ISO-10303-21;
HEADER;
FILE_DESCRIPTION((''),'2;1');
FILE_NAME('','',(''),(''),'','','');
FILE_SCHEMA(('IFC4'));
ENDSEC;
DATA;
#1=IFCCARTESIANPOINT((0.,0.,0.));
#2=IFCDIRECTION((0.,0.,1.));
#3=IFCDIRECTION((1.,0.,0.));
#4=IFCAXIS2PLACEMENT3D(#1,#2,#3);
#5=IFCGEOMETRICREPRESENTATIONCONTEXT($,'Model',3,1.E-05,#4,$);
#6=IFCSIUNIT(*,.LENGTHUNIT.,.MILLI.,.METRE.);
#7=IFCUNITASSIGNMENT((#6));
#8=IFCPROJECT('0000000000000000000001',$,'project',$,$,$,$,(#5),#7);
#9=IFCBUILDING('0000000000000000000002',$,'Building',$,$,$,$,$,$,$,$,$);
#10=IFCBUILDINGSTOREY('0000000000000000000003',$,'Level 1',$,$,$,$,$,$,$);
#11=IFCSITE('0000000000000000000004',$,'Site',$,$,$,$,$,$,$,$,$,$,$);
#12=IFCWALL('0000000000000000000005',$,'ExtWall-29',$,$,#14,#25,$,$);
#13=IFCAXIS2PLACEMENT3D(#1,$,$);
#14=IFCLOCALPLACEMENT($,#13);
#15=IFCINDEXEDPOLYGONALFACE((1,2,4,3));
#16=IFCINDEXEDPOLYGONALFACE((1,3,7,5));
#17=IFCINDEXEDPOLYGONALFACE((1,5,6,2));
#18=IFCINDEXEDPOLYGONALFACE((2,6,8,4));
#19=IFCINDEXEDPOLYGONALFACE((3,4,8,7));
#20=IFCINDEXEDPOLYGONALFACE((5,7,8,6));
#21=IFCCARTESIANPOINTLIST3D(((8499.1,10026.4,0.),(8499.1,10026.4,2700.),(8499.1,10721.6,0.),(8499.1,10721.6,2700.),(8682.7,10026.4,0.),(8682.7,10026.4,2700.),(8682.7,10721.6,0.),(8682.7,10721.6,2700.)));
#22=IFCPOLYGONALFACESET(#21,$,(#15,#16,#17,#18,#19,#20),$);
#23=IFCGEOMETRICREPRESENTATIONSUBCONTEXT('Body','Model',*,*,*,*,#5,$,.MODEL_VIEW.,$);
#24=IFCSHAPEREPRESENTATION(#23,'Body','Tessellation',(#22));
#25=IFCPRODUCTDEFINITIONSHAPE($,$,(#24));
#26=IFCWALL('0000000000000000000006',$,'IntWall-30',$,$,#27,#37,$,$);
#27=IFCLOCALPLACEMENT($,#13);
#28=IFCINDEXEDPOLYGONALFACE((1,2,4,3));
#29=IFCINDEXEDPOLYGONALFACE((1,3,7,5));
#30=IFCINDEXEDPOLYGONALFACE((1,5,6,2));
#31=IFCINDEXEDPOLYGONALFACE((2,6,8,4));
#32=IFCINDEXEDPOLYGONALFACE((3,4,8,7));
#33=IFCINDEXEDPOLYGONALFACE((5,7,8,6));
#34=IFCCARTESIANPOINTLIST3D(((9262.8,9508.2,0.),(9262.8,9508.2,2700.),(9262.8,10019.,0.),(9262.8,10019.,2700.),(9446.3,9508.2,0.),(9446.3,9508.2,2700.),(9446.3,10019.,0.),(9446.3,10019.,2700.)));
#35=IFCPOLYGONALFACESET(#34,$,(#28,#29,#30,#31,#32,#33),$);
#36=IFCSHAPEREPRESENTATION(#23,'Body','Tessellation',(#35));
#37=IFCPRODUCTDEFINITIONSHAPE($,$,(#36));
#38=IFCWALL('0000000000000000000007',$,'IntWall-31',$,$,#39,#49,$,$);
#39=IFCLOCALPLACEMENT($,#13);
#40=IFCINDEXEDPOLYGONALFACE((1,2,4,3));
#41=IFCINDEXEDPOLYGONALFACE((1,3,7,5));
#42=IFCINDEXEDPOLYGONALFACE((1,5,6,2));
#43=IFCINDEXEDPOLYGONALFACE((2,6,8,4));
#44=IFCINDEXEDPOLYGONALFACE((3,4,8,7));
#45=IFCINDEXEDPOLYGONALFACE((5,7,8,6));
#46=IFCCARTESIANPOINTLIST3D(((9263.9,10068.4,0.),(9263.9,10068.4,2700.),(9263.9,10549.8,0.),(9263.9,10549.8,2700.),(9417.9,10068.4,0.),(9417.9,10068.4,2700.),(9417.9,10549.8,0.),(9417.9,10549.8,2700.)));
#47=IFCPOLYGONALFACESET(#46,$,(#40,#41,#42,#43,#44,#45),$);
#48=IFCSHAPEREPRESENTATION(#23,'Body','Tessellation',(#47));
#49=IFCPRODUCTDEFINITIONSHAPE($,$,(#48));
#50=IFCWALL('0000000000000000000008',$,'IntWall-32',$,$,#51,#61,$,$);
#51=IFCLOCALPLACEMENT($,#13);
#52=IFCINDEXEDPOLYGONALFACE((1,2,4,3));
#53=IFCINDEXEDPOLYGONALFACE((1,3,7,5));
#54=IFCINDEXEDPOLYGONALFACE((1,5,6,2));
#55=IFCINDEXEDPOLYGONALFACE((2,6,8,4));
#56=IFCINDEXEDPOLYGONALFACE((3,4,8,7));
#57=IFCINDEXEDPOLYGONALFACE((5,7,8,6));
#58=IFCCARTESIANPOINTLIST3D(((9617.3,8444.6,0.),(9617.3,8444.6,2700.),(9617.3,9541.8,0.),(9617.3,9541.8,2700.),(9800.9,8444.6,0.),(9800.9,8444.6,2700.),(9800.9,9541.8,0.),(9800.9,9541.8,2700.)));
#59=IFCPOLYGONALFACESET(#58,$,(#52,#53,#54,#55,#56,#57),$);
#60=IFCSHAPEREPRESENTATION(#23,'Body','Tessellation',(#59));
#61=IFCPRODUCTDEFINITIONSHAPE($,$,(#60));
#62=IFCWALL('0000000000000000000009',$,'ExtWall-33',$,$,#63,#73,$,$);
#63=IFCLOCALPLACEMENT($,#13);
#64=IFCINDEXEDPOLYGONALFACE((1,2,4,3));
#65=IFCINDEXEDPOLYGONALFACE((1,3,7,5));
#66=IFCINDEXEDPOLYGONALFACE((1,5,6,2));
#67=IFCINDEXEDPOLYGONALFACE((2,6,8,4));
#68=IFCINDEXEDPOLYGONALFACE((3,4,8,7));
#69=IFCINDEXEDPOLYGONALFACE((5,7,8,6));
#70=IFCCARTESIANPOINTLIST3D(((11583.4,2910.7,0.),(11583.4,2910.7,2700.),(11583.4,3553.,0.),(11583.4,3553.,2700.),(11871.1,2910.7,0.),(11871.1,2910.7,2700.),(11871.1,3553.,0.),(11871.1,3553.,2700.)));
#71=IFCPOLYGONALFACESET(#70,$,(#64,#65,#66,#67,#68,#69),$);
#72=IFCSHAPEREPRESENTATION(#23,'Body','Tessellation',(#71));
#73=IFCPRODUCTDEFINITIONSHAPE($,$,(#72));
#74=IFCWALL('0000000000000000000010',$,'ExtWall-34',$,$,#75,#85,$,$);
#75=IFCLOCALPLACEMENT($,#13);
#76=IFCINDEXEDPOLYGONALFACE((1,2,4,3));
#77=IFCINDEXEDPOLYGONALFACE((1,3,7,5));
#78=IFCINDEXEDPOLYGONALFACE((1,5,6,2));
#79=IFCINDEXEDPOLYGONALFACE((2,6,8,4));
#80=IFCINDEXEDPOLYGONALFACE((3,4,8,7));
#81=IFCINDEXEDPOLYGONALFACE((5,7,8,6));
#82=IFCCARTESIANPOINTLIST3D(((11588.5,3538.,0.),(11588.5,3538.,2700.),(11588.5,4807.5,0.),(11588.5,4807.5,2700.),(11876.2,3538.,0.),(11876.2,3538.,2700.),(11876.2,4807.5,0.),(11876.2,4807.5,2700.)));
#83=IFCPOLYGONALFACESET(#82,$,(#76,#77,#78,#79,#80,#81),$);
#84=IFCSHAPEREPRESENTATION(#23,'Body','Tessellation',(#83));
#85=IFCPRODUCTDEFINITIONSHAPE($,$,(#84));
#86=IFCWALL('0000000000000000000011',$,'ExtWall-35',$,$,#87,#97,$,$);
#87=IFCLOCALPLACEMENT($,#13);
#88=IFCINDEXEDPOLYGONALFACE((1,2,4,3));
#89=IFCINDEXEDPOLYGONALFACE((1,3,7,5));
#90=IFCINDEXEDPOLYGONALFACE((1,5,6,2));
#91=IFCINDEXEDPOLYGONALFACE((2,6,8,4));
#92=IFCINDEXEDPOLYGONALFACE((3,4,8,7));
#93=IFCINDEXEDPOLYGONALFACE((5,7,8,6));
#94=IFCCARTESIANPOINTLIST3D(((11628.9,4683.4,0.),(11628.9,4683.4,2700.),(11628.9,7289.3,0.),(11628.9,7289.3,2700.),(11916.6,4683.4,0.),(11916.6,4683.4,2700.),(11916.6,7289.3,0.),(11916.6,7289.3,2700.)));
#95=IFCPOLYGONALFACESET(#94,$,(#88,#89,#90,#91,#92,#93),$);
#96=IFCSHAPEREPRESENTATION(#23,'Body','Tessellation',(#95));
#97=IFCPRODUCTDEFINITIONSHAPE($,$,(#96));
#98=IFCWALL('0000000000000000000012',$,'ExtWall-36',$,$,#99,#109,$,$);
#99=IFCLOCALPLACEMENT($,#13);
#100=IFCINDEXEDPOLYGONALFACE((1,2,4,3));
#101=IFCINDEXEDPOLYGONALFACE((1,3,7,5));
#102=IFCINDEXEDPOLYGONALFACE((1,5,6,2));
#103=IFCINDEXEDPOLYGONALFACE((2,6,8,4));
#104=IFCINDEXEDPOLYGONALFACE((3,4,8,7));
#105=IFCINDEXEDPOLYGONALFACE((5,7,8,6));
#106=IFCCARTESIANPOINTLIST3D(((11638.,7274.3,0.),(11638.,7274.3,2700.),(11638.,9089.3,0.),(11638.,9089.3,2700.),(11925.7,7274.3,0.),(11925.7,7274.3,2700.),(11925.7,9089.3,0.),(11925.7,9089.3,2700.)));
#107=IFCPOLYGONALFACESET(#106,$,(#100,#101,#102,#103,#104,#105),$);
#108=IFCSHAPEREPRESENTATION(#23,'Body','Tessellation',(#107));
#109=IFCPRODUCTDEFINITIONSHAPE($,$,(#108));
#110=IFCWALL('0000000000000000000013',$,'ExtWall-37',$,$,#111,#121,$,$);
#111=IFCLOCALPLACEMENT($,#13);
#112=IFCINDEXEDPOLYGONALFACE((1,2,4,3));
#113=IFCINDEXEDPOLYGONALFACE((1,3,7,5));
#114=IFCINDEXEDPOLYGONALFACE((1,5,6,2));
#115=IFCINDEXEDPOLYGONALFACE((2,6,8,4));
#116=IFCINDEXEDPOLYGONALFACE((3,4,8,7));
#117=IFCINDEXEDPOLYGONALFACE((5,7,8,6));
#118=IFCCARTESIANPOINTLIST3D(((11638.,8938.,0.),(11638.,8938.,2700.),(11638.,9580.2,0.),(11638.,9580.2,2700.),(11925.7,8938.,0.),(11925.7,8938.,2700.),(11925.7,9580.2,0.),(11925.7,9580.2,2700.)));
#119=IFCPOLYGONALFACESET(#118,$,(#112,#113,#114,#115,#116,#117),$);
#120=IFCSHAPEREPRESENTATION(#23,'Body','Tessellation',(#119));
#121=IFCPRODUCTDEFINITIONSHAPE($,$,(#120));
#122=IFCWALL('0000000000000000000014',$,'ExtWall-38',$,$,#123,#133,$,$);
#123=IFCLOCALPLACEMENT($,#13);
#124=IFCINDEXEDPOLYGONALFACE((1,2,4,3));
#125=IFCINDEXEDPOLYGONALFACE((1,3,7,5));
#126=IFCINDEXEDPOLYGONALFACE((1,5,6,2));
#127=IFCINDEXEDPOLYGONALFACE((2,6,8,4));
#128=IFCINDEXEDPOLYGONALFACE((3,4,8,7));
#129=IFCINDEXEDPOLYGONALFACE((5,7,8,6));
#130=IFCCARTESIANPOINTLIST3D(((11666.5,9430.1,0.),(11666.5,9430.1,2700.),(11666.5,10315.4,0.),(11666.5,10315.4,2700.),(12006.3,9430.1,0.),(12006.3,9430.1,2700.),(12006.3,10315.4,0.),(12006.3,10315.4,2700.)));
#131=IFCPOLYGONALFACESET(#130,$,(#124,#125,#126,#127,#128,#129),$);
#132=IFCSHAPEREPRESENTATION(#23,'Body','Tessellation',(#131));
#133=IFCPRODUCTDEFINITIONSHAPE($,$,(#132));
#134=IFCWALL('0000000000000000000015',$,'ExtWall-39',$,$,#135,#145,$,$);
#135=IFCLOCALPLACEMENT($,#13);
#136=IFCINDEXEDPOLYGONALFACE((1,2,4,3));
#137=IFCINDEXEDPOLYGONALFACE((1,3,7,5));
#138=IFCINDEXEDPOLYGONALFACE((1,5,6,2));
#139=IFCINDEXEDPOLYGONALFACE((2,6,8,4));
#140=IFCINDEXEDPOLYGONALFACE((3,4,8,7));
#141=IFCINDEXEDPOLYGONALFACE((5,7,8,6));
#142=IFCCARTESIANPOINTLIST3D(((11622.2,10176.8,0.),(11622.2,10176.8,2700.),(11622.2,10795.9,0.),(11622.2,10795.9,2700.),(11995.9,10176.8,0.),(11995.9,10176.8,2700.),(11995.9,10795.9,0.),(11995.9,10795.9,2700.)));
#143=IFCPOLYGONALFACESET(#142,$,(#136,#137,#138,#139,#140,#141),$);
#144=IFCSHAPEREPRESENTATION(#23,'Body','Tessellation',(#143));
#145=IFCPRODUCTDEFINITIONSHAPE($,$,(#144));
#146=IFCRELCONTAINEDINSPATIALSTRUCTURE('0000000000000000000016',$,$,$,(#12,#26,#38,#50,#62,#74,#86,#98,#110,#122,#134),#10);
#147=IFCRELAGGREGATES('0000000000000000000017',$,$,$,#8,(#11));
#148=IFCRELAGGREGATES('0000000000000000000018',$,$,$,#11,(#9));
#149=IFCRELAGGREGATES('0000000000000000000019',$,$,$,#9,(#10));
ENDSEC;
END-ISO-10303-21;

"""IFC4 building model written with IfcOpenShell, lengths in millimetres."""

from ifc_helpers import new_model, si_unit, frame, origin_with_axes, place, context, subcontext, project, spatial, indexed_curve, outline, extrude, element, save


model = new_model("IFC4")

# Units and contexts
model_context = context("Model", 3, precision=1e-05, world=origin_with_axes())
body_context = subcontext(model_context, "Body", "Model", "MODEL_VIEW")
ifc_project = project(units=[si_unit("LENGTHUNIT", "METRE", prefix="MILLI")], contexts=[model_context])

# Site, building, storey
site = spatial("IfcSite", under=ifc_project, Name="Site")
building = spatial("IfcBuilding", under=site, Name="Building")
storey = spatial("IfcBuildingStorey", under=building, Name="Level 1")

# Walls
wall_1_placement = place(None, frame((8590.9, 10026.4, 0.0), z_axis=(0.0, 0.0, 1.0), x_axis=(0.0, 1.0, 0.0)))
element("IfcWall", 1, at=wall_1_placement, inside=storey, Name="ExtWall-29", context=body_context, shape_type="SweptSolid", body=[
    extrude(outline(indexed_curve([(0.0, 0.0), (0.0, 183.5), (695.2, 183.5), (695.2, 0.0), (0.0, 0.0)], self_intersect=False)), frame((0.0, -91.8, 0.0), z_axis=(0.0, 0.0, 1.0), x_axis=(1.0, 0.0, 0.0)), (0.0, 0.0, 1.0), 2700.0),
])
wall_2_placement = place(None, frame((9354.5, 9508.2, 0.0), z_axis=(0.0, 0.0, 1.0), x_axis=(0.0, 1.0, 0.0)))
element("IfcWall", 2, at=wall_2_placement, inside=storey, Name="IntWall-30", context=body_context, shape_type="SweptSolid", body=[
    extrude(outline(indexed_curve([(0.0, 0.0), (0.0, 183.5), (510.8, 183.5), (510.8, 0.0), (0.0, 0.0)], self_intersect=False)), frame((0.0, -91.8, 0.0), z_axis=(0.0, 0.0, 1.0), x_axis=(1.0, 0.0, 0.0)), (0.0, 0.0, 1.0), 2700.0),
])
wall_3_placement = place(None, frame((9340.9, 10068.4, 0.0), z_axis=(0.0, 0.0, 1.0), x_axis=(0.0, 1.0, 0.0)))
element("IfcWall", 3, at=wall_3_placement, inside=storey, Name="IntWall-31", context=body_context, shape_type="SweptSolid", body=[
    extrude(outline(indexed_curve([(0.0, 0.0), (0.0, 154.1), (481.3, 154.1), (481.3, 0.0), (0.0, 0.0)], self_intersect=False)), frame((0.0, -77.0, 0.0), z_axis=(0.0, 0.0, 1.0), x_axis=(1.0, 0.0, 0.0)), (0.0, 0.0, 1.0), 2700.0),
])
wall_4_placement = place(None, frame((9709.1, 8444.6, 0.0), z_axis=(0.0, 0.0, 1.0), x_axis=(0.0, 1.0, 0.0)))
element("IfcWall", 4, at=wall_4_placement, inside=storey, Name="IntWall-32", context=body_context, shape_type="SweptSolid", body=[
    extrude(outline(indexed_curve([(0.0, 0.0), (0.0, 183.5), (1097.2, 183.5), (1097.2, 0.0), (0.0, 0.0)], self_intersect=False)), frame((0.0, -91.8, 0.0), z_axis=(0.0, 0.0, 1.0), x_axis=(1.0, 0.0, 0.0)), (0.0, 0.0, 1.0), 2700.0),
])
wall_5_placement = place(None, frame((11727.3, 2910.7, 0.0), z_axis=(0.0, 0.0, 1.0), x_axis=(0.0, 1.0, 0.0)))
element("IfcWall", 5, at=wall_5_placement, inside=storey, Name="ExtWall-33", context=body_context, shape_type="SweptSolid", body=[
    extrude(outline(indexed_curve([(0.0, 0.0), (0.0, 287.7), (642.3, 287.7), (642.3, 0.0), (0.0, 0.0)], self_intersect=False)), frame((0.0, -143.9, 0.0), z_axis=(0.0, 0.0, 1.0), x_axis=(1.0, 0.0, 0.0)), (0.0, 0.0, 1.0), 2700.0),
])
wall_6_placement = place(None, frame((11732.3, 3538.0, 0.0), z_axis=(0.0, 0.0, 1.0), x_axis=(0.0, 1.0, 0.0)))
element("IfcWall", 6, at=wall_6_placement, inside=storey, Name="ExtWall-34", context=body_context, shape_type="SweptSolid", body=[
    extrude(outline(indexed_curve([(0.0, 0.0), (0.0, 287.7), (1269.5, 287.7), (1269.5, 0.0), (0.0, 0.0)], self_intersect=False)), frame((0.0, -143.9, 0.0), z_axis=(0.0, 0.0, 1.0), x_axis=(1.0, 0.0, 0.0)), (0.0, 0.0, 1.0), 2700.0),
])
wall_7_placement = place(None, frame((11772.7, 4683.4, 0.0), z_axis=(0.0, 0.0, 1.0), x_axis=(0.0, 1.0, 0.0)))
element("IfcWall", 7, at=wall_7_placement, inside=storey, Name="ExtWall-35", context=body_context, shape_type="SweptSolid", body=[
    extrude(outline(indexed_curve([(0.0, 0.0), (0.0, 287.7), (2605.9, 287.7), (2605.9, 0.0), (0.0, 0.0)], self_intersect=False)), frame((0.0, -143.9, 0.0), z_axis=(0.0, 0.0, 1.0), x_axis=(1.0, 0.0, 0.0)), (0.0, 0.0, 1.0), 2700.0),
])
wall_8_placement = place(None, frame((11781.8, 7274.3, 0.0), z_axis=(0.0, 0.0, 1.0), x_axis=(0.0, 1.0, 0.0)))
element("IfcWall", 8, at=wall_8_placement, inside=storey, Name="ExtWall-36", context=body_context, shape_type="SweptSolid", body=[
    extrude(outline(indexed_curve([(0.0, 0.0), (0.0, 287.7), (1815.0, 287.7), (1815.0, 0.0), (0.0, 0.0)], self_intersect=False)), frame((0.0, -143.9, 0.0), z_axis=(0.0, 0.0, 1.0), x_axis=(1.0, 0.0, 0.0)), (0.0, 0.0, 1.0), 2700.0),
])
wall_9_placement = place(None, frame((11781.8, 8938.0, 0.0), z_axis=(0.0, 0.0, 1.0), x_axis=(0.0, 1.0, 0.0)))
element("IfcWall", 9, at=wall_9_placement, inside=storey, Name="ExtWall-37", context=body_context, shape_type="SweptSolid", body=[
    extrude(outline(indexed_curve([(0.0, 0.0), (0.0, 287.7), (642.3, 287.7), (642.3, 0.0), (0.0, 0.0)], self_intersect=False)), frame((0.0, -143.9, 0.0), z_axis=(0.0, 0.0, 1.0), x_axis=(1.0, 0.0, 0.0)), (0.0, 0.0, 1.0), 2700.0),
])
wall_10_placement = place(None, frame((11836.4, 9430.1, 0.0), z_axis=(0.0, 0.0, 1.0), x_axis=(0.0, 1.0, 0.0)))
element("IfcWall", 10, at=wall_10_placement, inside=storey, Name="ExtWall-38", context=body_context, shape_type="SweptSolid", body=[
    extrude(outline(indexed_curve([(0.0, 0.0), (0.0, 339.8), (885.3, 339.8), (885.3, 0.0), (0.0, 0.0)], self_intersect=False)), frame((0.0, -169.9, 0.0), z_axis=(0.0, 0.0, 1.0), x_axis=(1.0, 0.0, 0.0)), (0.0, 0.0, 1.0), 2700.0),
])
wall_11_placement = place(None, frame((11809.1, 10176.8, 0.0), z_axis=(0.0, 0.0, 1.0), x_axis=(0.0, 1.0, 0.0)))
element("IfcWall", 11, at=wall_11_placement, inside=storey, Name="ExtWall-39", context=body_context, shape_type="SweptSolid", body=[
    extrude(outline(indexed_curve([(0.0, 0.0), (0.0, 373.7), (619.2, 373.7), (619.2, 0.0), (0.0, 0.0)], self_intersect=False)), frame((0.0, -186.9, 0.0), z_axis=(0.0, 0.0, 1.0), x_axis=(1.0, 0.0, 0.0)), (0.0, 0.0, 1.0), 2700.0),
])

save(model, "model.ifc")
